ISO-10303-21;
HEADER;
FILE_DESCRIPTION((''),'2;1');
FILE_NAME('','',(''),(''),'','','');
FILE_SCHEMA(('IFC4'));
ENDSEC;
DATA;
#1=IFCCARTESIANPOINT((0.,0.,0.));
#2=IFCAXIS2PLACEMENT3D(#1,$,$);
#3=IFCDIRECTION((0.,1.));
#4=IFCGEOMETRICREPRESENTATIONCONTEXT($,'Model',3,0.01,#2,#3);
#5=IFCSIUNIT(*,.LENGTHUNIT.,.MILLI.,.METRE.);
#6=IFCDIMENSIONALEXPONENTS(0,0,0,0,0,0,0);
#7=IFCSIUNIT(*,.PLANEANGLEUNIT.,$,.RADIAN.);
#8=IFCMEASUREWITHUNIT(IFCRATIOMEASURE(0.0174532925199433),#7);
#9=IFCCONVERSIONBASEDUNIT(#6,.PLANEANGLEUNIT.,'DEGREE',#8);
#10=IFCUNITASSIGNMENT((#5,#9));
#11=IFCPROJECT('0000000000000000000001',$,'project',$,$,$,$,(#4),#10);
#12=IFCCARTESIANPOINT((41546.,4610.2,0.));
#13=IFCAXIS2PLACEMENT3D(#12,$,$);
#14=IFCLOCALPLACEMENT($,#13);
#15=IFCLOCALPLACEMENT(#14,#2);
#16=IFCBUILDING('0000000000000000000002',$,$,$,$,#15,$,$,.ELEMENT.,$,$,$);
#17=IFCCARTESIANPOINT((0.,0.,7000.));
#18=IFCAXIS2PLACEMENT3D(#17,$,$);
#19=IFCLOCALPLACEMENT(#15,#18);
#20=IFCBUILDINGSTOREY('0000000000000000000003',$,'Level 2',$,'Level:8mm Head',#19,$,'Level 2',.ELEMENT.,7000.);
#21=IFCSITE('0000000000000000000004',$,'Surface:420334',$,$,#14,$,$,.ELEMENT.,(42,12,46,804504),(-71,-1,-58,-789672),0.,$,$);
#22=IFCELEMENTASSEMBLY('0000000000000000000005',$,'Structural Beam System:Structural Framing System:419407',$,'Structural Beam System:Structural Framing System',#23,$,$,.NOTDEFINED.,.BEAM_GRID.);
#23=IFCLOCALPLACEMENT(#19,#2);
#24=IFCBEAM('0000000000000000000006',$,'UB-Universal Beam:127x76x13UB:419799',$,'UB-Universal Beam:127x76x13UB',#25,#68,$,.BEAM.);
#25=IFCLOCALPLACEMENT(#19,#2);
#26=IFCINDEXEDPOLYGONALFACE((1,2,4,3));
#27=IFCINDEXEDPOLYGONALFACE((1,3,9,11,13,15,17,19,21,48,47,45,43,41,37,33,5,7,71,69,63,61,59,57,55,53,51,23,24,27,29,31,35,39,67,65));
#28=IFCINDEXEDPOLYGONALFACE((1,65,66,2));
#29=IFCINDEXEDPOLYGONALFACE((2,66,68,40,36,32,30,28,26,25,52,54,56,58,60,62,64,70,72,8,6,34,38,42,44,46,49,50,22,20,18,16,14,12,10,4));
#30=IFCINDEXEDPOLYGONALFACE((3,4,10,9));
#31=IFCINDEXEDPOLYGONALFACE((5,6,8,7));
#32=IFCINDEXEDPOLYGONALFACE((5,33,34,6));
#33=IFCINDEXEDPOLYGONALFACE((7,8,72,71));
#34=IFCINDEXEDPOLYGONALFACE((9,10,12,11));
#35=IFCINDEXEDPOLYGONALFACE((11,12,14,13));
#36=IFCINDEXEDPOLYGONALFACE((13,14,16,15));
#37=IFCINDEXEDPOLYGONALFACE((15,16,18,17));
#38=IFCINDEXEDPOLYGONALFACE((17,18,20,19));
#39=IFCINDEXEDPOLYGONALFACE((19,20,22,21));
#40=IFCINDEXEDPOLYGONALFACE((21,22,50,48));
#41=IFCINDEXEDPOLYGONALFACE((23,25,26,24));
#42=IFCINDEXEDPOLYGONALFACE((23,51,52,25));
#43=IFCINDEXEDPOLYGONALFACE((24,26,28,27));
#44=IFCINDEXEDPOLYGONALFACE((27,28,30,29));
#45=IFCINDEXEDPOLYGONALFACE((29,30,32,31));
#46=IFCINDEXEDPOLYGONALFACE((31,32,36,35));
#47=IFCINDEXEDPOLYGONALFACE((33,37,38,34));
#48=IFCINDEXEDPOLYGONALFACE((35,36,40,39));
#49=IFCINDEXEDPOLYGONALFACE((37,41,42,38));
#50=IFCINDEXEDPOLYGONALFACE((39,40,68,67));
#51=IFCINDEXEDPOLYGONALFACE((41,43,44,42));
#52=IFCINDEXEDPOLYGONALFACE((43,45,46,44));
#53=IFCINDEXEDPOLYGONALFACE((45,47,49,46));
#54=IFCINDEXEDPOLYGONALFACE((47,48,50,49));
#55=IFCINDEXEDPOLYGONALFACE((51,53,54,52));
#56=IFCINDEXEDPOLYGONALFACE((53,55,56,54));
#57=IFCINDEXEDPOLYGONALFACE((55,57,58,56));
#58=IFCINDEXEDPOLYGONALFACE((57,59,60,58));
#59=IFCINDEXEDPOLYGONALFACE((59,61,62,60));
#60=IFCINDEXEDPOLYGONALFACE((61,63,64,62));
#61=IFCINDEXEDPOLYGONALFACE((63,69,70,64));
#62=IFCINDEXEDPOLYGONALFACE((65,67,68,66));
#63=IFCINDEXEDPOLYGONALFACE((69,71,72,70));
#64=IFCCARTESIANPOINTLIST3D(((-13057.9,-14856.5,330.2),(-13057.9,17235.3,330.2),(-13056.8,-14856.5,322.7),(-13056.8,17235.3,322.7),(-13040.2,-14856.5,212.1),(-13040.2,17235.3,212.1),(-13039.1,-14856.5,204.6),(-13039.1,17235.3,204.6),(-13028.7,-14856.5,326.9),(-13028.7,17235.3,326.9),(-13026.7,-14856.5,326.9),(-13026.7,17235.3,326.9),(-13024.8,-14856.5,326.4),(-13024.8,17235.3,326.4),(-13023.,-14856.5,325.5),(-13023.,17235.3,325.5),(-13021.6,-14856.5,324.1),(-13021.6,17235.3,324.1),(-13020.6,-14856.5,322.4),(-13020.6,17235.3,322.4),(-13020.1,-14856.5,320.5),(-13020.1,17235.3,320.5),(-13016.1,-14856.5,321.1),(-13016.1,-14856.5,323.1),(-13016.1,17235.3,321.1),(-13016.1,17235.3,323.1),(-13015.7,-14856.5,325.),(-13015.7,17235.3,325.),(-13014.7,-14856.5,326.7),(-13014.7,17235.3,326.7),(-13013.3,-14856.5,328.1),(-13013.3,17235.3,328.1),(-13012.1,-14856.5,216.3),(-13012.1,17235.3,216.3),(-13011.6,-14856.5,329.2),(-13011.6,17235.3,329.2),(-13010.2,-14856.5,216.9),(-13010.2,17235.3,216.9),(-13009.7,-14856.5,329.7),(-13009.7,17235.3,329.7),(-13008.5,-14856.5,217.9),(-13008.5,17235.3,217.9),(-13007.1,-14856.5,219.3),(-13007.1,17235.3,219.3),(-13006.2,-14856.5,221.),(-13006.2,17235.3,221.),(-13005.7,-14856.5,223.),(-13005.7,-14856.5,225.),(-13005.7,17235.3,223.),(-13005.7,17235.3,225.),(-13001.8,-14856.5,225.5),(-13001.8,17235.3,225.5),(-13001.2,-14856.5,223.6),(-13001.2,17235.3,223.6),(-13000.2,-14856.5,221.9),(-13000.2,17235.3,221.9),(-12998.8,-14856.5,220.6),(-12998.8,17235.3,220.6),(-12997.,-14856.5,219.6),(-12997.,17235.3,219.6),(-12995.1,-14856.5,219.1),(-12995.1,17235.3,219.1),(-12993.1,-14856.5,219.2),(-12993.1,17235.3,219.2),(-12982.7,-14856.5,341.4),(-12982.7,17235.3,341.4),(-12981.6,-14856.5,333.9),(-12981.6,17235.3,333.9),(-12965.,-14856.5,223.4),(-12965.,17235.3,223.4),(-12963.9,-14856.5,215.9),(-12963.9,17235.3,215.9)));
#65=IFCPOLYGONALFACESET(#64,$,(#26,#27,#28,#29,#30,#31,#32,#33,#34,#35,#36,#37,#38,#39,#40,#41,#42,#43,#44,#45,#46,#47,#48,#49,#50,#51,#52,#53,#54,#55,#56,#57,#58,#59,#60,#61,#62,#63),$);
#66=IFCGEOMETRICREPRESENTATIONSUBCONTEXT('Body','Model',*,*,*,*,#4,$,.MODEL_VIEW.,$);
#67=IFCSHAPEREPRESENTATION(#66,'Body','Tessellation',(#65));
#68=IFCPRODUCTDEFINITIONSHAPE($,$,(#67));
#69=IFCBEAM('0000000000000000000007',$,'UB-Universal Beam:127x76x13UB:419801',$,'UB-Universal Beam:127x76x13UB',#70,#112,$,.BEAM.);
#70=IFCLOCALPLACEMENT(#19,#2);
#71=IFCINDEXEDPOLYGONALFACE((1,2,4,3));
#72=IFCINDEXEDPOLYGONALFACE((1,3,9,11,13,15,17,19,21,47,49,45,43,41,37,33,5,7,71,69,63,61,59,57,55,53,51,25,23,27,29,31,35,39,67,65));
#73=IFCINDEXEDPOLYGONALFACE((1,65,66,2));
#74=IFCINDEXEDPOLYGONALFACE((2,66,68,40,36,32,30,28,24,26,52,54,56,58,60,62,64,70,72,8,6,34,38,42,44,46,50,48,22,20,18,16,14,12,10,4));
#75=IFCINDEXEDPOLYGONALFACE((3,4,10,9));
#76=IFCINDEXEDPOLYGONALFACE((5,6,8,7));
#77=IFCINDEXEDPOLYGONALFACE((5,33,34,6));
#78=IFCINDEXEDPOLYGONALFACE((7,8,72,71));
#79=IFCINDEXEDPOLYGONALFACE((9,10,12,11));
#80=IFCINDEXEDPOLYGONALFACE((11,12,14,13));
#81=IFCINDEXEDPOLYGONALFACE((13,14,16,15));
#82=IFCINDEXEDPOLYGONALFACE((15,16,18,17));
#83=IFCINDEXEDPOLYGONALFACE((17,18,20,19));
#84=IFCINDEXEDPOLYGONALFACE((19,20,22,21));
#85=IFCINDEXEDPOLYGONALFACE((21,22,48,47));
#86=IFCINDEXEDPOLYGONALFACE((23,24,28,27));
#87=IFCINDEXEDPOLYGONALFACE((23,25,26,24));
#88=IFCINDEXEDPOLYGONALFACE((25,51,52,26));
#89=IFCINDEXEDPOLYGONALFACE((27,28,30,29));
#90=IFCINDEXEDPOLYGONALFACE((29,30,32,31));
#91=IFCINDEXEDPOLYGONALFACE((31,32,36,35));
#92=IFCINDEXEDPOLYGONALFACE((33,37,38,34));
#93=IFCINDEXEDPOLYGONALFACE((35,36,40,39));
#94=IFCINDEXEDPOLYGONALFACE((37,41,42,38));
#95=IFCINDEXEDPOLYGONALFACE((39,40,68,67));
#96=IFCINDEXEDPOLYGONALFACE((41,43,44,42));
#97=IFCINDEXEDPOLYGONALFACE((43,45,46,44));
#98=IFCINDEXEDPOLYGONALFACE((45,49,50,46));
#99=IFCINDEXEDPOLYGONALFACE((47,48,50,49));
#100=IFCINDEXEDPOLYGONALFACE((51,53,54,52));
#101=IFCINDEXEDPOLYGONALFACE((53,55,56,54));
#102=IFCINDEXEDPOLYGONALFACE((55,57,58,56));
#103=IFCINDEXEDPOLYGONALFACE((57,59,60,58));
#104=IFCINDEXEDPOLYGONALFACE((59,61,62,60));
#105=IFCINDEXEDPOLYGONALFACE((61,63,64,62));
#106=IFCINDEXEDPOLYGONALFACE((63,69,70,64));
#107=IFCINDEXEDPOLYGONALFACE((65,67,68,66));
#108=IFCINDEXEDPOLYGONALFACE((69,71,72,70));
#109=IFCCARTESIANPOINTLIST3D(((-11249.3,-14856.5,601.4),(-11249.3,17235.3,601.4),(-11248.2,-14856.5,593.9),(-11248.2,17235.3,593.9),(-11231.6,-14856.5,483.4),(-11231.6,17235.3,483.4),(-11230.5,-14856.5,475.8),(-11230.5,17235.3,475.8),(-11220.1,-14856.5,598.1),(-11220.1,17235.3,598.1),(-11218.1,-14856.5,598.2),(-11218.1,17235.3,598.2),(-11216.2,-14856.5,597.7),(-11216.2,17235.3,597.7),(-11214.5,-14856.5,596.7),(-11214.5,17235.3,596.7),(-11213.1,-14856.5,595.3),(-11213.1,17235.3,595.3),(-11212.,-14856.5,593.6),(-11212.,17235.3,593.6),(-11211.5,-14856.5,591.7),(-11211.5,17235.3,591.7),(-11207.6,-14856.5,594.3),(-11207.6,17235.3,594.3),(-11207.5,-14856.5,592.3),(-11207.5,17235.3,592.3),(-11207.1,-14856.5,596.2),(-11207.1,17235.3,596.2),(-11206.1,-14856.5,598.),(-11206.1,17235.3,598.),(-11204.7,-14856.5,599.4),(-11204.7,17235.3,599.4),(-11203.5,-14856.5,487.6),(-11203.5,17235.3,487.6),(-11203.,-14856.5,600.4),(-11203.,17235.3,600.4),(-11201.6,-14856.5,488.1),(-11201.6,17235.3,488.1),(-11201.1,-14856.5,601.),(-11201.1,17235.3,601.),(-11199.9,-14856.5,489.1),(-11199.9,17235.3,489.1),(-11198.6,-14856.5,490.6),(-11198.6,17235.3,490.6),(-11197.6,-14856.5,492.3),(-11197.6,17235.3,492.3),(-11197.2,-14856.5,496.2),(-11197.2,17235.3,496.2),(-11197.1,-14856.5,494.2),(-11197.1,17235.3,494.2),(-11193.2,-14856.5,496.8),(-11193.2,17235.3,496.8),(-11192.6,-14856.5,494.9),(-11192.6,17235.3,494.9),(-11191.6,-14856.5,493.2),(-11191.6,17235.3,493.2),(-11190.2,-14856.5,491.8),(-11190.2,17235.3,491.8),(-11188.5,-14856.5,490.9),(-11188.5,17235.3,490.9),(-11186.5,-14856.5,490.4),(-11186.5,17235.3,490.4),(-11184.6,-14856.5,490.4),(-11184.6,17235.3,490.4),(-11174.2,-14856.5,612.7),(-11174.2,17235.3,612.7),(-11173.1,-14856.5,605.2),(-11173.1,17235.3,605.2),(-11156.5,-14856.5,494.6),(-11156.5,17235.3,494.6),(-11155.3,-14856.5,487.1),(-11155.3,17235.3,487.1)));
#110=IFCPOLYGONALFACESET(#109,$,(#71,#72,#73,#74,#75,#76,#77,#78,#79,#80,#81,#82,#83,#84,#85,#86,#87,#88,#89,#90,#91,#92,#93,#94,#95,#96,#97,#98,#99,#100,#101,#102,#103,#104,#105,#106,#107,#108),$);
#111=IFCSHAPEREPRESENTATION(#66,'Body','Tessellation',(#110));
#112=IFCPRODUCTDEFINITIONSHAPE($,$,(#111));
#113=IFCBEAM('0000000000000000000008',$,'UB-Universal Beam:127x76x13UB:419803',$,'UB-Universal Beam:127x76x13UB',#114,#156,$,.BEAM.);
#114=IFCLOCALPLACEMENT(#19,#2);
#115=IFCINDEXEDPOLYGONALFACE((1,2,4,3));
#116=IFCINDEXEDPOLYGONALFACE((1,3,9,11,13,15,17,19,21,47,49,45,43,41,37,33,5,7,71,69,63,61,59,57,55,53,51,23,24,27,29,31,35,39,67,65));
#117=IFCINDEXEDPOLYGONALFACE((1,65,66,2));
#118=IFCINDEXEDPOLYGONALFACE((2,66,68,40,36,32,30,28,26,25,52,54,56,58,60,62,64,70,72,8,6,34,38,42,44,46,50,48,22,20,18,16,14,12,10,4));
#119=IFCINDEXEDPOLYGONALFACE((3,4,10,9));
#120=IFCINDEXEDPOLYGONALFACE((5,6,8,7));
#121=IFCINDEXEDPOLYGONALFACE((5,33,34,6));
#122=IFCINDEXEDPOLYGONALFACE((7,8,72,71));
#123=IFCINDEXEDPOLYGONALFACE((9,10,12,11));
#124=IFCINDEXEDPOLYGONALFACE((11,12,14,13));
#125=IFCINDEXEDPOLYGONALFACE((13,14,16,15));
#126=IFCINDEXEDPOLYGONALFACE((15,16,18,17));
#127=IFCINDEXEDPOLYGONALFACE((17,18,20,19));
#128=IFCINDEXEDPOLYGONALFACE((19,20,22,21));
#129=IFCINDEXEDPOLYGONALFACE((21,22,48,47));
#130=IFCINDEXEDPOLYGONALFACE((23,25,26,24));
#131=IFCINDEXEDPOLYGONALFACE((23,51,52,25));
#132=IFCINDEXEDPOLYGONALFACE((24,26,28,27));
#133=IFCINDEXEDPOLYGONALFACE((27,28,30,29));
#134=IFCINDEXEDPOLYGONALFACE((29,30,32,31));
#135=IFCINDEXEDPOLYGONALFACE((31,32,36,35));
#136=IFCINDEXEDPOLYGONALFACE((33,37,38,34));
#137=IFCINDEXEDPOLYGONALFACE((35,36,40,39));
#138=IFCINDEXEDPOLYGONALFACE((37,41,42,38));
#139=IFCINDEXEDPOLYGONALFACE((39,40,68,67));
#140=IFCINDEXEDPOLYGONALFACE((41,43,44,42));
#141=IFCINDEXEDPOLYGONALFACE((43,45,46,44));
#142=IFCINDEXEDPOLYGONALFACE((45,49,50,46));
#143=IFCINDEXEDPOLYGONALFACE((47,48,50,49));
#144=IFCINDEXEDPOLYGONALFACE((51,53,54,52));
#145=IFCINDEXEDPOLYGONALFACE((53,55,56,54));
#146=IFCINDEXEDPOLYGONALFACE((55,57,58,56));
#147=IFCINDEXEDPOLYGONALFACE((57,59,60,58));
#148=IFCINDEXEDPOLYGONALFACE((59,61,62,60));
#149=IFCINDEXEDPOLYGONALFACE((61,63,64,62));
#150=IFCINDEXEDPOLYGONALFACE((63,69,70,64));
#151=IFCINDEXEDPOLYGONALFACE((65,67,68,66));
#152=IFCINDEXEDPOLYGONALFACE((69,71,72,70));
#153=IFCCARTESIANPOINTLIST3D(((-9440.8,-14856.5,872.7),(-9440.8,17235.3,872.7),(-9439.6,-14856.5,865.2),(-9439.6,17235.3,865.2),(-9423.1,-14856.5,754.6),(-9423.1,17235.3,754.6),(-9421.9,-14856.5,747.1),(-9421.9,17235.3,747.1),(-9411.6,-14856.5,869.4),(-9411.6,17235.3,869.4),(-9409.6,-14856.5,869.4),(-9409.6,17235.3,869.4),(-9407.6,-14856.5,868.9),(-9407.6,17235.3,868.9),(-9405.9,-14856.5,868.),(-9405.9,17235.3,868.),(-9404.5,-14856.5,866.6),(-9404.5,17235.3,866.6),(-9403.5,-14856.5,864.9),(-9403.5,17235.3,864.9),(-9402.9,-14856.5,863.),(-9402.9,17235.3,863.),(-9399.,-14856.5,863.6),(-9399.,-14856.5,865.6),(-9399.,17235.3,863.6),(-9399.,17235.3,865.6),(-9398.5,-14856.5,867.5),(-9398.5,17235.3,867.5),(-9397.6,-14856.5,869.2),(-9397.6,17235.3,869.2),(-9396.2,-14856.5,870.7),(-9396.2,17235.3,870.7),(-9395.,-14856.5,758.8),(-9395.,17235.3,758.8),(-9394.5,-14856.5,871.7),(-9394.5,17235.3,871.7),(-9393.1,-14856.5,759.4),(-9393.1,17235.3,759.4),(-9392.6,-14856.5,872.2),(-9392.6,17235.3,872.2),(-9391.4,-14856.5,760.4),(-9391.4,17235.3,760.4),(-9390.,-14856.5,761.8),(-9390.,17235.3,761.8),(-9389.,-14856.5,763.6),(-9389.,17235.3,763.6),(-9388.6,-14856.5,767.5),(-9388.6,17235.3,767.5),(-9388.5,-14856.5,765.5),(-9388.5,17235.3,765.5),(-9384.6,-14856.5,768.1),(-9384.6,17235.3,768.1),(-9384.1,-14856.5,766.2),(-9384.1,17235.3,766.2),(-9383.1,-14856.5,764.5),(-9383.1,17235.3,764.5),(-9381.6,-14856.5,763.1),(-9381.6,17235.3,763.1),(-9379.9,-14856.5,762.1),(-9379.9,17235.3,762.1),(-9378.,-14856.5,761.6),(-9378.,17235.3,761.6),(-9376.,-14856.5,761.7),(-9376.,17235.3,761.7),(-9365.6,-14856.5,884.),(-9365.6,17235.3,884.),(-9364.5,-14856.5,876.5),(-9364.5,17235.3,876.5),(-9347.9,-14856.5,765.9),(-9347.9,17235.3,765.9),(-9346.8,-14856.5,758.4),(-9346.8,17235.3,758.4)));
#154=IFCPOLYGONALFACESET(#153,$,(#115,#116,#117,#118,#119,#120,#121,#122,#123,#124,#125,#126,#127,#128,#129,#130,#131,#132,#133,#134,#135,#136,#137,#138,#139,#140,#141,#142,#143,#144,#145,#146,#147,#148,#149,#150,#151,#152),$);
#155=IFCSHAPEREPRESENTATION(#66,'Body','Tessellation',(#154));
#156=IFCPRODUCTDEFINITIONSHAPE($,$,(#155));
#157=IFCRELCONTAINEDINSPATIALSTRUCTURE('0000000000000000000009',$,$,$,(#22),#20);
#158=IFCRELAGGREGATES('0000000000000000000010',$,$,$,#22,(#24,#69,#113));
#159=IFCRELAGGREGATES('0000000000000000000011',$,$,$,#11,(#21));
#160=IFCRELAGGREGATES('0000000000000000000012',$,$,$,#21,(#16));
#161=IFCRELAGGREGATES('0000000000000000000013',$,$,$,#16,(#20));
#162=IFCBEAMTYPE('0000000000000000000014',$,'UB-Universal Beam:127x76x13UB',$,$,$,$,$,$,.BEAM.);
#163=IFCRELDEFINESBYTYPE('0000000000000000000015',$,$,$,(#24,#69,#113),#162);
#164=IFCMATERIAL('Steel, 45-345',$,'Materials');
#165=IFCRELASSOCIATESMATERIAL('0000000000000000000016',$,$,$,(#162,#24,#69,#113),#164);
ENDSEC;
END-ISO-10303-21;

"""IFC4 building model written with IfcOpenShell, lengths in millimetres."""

from ifc_helpers import new_model, entity, si_unit, converted_unit, direction, frame, frame_2d, origin, place, context, subcontext, project, spatial, i_section, extrude, source, transform, mapped, material, material_profile, profile_set, profile_usage, type_object, type_shapes, element, aggregate, save


model = new_model("IFC4")

# Units and contexts
model_context = context("Model", 3, precision=0.01, world=origin(), true_north=direction((0.0, 1.0)))
body_context = subcontext(model_context, "Body", "Model", "MODEL_VIEW")
ifc_project = project(units=[si_unit("LENGTHUNIT", "METRE", prefix="MILLI"), converted_unit("PLANEANGLEUNIT", "DEGREE", entity("IfcRatioMeasure", 0.0174532925199433), si_unit("PLANEANGLEUNIT", "RADIAN"), dimensions=[0, 0, 0, 0, 0, 0, 0])], contexts=[model_context])

# Site, building, storey
site_placement = place(None, frame((41546.0, 4610.2, 0.0)))
site = spatial("IfcSite", under=ifc_project, at=site_placement, Name="Surface:420334", CompositionType="ELEMENT", RefLatitude=(42, 12, 46, 804504), RefLongitude=(-71, -1, -58, -789672), RefElevation=0.0)
building_placement = place(site_placement, origin())
building = spatial("IfcBuilding", under=site, at=building_placement, CompositionType="ELEMENT")
storey_placement = place(building_placement, frame((0.0, 0.0, 7000.0)))
storey = spatial("IfcBuildingStorey", under=building, at=storey_placement, Name="Level 2", ObjectType="Level:8mm Head", LongName="Level 2", CompositionType="ELEMENT", Elevation=7000.0)

# Element assembly, beams
assembly_placement = place(storey_placement, origin())
assembly = element("IfcElementAssembly", 1, at=assembly_placement, inside=storey, Name="Structural Beam System:Structural Framing System:419407", ObjectType="Structural Beam System:Structural Framing System", AssemblyPlace="NOTDEFINED", PredefinedType="BEAM_GRID")
ifc_material_1 = material(Name="Steel, 45-345", Category="Materials")
ifc_material_profile = material_profile(ifc_material_1, i_section(OverallWidth=76.0, OverallDepth=127.0, WebThickness=4.0, FlangeThickness=7.6, FilletRadius=7.6, at=frame_2d((0.0, 0.0), x_axis=(0.0, 1.0))), Name="127x76x13UB")
ifc_profile_set = profile_set([ifc_material_profile], Name="127x76x13UB")
ifc_profile_usage_1 = profile_usage(ifc_profile_set, cardinal=8)
beam_type = type_object("IfcBeamType", Name="UB-Universal Beam:127x76x13UB", PredefinedType="BEAM", material=ifc_profile_set)
shared_shape = source(origin(), body_context, "Body", "SweptSolid", [
    extrude(i_section(OverallWidth=76.0, OverallDepth=127.0, WebThickness=4.0, FlangeThickness=7.6, FilletRadius=7.6, at=frame_2d((0.0, 0.0), x_axis=(0.0, 1.0))), frame((-15973.5, 0.0, 0.0), z_axis=(1.0, 0.0, 0.0), x_axis=(0.0, 0.0, -1.0)), (0.0, 0.0, 1.0), 32091.8),
])
type_shapes(beam_type, [shared_shape])
beam_1_placement = place(assembly_placement, frame((-13010.9, 1261.8, 273.0), z_axis=(-0.148327, 0.0, 0.988938), x_axis=(0.0, -1.0, 0.0)))
beam_1 = element("IfcBeam", 2, at=beam_1_placement, type_object=beam_type, material=ifc_profile_usage_1, Name="UB-Universal Beam:127x76x13UB:419799", ObjectType="UB-Universal Beam:127x76x13UB", PredefinedType="BEAM", context=body_context, shape_type="MappedRepresentation", body=[
    mapped(shared_shape, transform((0.0, 0.0, 0.0), scale=1.0)),
])
ifc_profile_usage_2 = profile_usage(ifc_profile_set, cardinal=8)
beam_2_placement = place(assembly_placement, frame((-11202.3, 1261.8, 544.3), z_axis=(-0.148327, 0.0, 0.988938), x_axis=(0.0, -1.0, 0.0)))
beam_2 = element("IfcBeam", 3, at=beam_2_placement, type_object=beam_type, material=ifc_profile_usage_2, Name="UB-Universal Beam:127x76x13UB:419801", ObjectType="UB-Universal Beam:127x76x13UB", PredefinedType="BEAM", context=body_context, shape_type="MappedRepresentation", body=[
    mapped(shared_shape, transform((0.0, 0.0, 0.0), scale=1.0)),
])
ifc_profile_usage_3 = profile_usage(ifc_profile_set, cardinal=8)
beam_3_placement = place(assembly_placement, frame((-9393.8, 1261.8, 815.5), z_axis=(-0.148327, 0.0, 0.988938), x_axis=(0.0, -1.0, 0.0)))
beam_3 = element("IfcBeam", 4, at=beam_3_placement, type_object=beam_type, material=ifc_profile_usage_3, Name="UB-Universal Beam:127x76x13UB:419803", ObjectType="UB-Universal Beam:127x76x13UB", PredefinedType="BEAM", context=body_context, shape_type="MappedRepresentation", body=[
    mapped(shared_shape, transform((0.0, 0.0, 0.0), scale=1.0)),
])
aggregate(assembly, [beam_1, beam_2, beam_3])

save(model, "model.ifc")
